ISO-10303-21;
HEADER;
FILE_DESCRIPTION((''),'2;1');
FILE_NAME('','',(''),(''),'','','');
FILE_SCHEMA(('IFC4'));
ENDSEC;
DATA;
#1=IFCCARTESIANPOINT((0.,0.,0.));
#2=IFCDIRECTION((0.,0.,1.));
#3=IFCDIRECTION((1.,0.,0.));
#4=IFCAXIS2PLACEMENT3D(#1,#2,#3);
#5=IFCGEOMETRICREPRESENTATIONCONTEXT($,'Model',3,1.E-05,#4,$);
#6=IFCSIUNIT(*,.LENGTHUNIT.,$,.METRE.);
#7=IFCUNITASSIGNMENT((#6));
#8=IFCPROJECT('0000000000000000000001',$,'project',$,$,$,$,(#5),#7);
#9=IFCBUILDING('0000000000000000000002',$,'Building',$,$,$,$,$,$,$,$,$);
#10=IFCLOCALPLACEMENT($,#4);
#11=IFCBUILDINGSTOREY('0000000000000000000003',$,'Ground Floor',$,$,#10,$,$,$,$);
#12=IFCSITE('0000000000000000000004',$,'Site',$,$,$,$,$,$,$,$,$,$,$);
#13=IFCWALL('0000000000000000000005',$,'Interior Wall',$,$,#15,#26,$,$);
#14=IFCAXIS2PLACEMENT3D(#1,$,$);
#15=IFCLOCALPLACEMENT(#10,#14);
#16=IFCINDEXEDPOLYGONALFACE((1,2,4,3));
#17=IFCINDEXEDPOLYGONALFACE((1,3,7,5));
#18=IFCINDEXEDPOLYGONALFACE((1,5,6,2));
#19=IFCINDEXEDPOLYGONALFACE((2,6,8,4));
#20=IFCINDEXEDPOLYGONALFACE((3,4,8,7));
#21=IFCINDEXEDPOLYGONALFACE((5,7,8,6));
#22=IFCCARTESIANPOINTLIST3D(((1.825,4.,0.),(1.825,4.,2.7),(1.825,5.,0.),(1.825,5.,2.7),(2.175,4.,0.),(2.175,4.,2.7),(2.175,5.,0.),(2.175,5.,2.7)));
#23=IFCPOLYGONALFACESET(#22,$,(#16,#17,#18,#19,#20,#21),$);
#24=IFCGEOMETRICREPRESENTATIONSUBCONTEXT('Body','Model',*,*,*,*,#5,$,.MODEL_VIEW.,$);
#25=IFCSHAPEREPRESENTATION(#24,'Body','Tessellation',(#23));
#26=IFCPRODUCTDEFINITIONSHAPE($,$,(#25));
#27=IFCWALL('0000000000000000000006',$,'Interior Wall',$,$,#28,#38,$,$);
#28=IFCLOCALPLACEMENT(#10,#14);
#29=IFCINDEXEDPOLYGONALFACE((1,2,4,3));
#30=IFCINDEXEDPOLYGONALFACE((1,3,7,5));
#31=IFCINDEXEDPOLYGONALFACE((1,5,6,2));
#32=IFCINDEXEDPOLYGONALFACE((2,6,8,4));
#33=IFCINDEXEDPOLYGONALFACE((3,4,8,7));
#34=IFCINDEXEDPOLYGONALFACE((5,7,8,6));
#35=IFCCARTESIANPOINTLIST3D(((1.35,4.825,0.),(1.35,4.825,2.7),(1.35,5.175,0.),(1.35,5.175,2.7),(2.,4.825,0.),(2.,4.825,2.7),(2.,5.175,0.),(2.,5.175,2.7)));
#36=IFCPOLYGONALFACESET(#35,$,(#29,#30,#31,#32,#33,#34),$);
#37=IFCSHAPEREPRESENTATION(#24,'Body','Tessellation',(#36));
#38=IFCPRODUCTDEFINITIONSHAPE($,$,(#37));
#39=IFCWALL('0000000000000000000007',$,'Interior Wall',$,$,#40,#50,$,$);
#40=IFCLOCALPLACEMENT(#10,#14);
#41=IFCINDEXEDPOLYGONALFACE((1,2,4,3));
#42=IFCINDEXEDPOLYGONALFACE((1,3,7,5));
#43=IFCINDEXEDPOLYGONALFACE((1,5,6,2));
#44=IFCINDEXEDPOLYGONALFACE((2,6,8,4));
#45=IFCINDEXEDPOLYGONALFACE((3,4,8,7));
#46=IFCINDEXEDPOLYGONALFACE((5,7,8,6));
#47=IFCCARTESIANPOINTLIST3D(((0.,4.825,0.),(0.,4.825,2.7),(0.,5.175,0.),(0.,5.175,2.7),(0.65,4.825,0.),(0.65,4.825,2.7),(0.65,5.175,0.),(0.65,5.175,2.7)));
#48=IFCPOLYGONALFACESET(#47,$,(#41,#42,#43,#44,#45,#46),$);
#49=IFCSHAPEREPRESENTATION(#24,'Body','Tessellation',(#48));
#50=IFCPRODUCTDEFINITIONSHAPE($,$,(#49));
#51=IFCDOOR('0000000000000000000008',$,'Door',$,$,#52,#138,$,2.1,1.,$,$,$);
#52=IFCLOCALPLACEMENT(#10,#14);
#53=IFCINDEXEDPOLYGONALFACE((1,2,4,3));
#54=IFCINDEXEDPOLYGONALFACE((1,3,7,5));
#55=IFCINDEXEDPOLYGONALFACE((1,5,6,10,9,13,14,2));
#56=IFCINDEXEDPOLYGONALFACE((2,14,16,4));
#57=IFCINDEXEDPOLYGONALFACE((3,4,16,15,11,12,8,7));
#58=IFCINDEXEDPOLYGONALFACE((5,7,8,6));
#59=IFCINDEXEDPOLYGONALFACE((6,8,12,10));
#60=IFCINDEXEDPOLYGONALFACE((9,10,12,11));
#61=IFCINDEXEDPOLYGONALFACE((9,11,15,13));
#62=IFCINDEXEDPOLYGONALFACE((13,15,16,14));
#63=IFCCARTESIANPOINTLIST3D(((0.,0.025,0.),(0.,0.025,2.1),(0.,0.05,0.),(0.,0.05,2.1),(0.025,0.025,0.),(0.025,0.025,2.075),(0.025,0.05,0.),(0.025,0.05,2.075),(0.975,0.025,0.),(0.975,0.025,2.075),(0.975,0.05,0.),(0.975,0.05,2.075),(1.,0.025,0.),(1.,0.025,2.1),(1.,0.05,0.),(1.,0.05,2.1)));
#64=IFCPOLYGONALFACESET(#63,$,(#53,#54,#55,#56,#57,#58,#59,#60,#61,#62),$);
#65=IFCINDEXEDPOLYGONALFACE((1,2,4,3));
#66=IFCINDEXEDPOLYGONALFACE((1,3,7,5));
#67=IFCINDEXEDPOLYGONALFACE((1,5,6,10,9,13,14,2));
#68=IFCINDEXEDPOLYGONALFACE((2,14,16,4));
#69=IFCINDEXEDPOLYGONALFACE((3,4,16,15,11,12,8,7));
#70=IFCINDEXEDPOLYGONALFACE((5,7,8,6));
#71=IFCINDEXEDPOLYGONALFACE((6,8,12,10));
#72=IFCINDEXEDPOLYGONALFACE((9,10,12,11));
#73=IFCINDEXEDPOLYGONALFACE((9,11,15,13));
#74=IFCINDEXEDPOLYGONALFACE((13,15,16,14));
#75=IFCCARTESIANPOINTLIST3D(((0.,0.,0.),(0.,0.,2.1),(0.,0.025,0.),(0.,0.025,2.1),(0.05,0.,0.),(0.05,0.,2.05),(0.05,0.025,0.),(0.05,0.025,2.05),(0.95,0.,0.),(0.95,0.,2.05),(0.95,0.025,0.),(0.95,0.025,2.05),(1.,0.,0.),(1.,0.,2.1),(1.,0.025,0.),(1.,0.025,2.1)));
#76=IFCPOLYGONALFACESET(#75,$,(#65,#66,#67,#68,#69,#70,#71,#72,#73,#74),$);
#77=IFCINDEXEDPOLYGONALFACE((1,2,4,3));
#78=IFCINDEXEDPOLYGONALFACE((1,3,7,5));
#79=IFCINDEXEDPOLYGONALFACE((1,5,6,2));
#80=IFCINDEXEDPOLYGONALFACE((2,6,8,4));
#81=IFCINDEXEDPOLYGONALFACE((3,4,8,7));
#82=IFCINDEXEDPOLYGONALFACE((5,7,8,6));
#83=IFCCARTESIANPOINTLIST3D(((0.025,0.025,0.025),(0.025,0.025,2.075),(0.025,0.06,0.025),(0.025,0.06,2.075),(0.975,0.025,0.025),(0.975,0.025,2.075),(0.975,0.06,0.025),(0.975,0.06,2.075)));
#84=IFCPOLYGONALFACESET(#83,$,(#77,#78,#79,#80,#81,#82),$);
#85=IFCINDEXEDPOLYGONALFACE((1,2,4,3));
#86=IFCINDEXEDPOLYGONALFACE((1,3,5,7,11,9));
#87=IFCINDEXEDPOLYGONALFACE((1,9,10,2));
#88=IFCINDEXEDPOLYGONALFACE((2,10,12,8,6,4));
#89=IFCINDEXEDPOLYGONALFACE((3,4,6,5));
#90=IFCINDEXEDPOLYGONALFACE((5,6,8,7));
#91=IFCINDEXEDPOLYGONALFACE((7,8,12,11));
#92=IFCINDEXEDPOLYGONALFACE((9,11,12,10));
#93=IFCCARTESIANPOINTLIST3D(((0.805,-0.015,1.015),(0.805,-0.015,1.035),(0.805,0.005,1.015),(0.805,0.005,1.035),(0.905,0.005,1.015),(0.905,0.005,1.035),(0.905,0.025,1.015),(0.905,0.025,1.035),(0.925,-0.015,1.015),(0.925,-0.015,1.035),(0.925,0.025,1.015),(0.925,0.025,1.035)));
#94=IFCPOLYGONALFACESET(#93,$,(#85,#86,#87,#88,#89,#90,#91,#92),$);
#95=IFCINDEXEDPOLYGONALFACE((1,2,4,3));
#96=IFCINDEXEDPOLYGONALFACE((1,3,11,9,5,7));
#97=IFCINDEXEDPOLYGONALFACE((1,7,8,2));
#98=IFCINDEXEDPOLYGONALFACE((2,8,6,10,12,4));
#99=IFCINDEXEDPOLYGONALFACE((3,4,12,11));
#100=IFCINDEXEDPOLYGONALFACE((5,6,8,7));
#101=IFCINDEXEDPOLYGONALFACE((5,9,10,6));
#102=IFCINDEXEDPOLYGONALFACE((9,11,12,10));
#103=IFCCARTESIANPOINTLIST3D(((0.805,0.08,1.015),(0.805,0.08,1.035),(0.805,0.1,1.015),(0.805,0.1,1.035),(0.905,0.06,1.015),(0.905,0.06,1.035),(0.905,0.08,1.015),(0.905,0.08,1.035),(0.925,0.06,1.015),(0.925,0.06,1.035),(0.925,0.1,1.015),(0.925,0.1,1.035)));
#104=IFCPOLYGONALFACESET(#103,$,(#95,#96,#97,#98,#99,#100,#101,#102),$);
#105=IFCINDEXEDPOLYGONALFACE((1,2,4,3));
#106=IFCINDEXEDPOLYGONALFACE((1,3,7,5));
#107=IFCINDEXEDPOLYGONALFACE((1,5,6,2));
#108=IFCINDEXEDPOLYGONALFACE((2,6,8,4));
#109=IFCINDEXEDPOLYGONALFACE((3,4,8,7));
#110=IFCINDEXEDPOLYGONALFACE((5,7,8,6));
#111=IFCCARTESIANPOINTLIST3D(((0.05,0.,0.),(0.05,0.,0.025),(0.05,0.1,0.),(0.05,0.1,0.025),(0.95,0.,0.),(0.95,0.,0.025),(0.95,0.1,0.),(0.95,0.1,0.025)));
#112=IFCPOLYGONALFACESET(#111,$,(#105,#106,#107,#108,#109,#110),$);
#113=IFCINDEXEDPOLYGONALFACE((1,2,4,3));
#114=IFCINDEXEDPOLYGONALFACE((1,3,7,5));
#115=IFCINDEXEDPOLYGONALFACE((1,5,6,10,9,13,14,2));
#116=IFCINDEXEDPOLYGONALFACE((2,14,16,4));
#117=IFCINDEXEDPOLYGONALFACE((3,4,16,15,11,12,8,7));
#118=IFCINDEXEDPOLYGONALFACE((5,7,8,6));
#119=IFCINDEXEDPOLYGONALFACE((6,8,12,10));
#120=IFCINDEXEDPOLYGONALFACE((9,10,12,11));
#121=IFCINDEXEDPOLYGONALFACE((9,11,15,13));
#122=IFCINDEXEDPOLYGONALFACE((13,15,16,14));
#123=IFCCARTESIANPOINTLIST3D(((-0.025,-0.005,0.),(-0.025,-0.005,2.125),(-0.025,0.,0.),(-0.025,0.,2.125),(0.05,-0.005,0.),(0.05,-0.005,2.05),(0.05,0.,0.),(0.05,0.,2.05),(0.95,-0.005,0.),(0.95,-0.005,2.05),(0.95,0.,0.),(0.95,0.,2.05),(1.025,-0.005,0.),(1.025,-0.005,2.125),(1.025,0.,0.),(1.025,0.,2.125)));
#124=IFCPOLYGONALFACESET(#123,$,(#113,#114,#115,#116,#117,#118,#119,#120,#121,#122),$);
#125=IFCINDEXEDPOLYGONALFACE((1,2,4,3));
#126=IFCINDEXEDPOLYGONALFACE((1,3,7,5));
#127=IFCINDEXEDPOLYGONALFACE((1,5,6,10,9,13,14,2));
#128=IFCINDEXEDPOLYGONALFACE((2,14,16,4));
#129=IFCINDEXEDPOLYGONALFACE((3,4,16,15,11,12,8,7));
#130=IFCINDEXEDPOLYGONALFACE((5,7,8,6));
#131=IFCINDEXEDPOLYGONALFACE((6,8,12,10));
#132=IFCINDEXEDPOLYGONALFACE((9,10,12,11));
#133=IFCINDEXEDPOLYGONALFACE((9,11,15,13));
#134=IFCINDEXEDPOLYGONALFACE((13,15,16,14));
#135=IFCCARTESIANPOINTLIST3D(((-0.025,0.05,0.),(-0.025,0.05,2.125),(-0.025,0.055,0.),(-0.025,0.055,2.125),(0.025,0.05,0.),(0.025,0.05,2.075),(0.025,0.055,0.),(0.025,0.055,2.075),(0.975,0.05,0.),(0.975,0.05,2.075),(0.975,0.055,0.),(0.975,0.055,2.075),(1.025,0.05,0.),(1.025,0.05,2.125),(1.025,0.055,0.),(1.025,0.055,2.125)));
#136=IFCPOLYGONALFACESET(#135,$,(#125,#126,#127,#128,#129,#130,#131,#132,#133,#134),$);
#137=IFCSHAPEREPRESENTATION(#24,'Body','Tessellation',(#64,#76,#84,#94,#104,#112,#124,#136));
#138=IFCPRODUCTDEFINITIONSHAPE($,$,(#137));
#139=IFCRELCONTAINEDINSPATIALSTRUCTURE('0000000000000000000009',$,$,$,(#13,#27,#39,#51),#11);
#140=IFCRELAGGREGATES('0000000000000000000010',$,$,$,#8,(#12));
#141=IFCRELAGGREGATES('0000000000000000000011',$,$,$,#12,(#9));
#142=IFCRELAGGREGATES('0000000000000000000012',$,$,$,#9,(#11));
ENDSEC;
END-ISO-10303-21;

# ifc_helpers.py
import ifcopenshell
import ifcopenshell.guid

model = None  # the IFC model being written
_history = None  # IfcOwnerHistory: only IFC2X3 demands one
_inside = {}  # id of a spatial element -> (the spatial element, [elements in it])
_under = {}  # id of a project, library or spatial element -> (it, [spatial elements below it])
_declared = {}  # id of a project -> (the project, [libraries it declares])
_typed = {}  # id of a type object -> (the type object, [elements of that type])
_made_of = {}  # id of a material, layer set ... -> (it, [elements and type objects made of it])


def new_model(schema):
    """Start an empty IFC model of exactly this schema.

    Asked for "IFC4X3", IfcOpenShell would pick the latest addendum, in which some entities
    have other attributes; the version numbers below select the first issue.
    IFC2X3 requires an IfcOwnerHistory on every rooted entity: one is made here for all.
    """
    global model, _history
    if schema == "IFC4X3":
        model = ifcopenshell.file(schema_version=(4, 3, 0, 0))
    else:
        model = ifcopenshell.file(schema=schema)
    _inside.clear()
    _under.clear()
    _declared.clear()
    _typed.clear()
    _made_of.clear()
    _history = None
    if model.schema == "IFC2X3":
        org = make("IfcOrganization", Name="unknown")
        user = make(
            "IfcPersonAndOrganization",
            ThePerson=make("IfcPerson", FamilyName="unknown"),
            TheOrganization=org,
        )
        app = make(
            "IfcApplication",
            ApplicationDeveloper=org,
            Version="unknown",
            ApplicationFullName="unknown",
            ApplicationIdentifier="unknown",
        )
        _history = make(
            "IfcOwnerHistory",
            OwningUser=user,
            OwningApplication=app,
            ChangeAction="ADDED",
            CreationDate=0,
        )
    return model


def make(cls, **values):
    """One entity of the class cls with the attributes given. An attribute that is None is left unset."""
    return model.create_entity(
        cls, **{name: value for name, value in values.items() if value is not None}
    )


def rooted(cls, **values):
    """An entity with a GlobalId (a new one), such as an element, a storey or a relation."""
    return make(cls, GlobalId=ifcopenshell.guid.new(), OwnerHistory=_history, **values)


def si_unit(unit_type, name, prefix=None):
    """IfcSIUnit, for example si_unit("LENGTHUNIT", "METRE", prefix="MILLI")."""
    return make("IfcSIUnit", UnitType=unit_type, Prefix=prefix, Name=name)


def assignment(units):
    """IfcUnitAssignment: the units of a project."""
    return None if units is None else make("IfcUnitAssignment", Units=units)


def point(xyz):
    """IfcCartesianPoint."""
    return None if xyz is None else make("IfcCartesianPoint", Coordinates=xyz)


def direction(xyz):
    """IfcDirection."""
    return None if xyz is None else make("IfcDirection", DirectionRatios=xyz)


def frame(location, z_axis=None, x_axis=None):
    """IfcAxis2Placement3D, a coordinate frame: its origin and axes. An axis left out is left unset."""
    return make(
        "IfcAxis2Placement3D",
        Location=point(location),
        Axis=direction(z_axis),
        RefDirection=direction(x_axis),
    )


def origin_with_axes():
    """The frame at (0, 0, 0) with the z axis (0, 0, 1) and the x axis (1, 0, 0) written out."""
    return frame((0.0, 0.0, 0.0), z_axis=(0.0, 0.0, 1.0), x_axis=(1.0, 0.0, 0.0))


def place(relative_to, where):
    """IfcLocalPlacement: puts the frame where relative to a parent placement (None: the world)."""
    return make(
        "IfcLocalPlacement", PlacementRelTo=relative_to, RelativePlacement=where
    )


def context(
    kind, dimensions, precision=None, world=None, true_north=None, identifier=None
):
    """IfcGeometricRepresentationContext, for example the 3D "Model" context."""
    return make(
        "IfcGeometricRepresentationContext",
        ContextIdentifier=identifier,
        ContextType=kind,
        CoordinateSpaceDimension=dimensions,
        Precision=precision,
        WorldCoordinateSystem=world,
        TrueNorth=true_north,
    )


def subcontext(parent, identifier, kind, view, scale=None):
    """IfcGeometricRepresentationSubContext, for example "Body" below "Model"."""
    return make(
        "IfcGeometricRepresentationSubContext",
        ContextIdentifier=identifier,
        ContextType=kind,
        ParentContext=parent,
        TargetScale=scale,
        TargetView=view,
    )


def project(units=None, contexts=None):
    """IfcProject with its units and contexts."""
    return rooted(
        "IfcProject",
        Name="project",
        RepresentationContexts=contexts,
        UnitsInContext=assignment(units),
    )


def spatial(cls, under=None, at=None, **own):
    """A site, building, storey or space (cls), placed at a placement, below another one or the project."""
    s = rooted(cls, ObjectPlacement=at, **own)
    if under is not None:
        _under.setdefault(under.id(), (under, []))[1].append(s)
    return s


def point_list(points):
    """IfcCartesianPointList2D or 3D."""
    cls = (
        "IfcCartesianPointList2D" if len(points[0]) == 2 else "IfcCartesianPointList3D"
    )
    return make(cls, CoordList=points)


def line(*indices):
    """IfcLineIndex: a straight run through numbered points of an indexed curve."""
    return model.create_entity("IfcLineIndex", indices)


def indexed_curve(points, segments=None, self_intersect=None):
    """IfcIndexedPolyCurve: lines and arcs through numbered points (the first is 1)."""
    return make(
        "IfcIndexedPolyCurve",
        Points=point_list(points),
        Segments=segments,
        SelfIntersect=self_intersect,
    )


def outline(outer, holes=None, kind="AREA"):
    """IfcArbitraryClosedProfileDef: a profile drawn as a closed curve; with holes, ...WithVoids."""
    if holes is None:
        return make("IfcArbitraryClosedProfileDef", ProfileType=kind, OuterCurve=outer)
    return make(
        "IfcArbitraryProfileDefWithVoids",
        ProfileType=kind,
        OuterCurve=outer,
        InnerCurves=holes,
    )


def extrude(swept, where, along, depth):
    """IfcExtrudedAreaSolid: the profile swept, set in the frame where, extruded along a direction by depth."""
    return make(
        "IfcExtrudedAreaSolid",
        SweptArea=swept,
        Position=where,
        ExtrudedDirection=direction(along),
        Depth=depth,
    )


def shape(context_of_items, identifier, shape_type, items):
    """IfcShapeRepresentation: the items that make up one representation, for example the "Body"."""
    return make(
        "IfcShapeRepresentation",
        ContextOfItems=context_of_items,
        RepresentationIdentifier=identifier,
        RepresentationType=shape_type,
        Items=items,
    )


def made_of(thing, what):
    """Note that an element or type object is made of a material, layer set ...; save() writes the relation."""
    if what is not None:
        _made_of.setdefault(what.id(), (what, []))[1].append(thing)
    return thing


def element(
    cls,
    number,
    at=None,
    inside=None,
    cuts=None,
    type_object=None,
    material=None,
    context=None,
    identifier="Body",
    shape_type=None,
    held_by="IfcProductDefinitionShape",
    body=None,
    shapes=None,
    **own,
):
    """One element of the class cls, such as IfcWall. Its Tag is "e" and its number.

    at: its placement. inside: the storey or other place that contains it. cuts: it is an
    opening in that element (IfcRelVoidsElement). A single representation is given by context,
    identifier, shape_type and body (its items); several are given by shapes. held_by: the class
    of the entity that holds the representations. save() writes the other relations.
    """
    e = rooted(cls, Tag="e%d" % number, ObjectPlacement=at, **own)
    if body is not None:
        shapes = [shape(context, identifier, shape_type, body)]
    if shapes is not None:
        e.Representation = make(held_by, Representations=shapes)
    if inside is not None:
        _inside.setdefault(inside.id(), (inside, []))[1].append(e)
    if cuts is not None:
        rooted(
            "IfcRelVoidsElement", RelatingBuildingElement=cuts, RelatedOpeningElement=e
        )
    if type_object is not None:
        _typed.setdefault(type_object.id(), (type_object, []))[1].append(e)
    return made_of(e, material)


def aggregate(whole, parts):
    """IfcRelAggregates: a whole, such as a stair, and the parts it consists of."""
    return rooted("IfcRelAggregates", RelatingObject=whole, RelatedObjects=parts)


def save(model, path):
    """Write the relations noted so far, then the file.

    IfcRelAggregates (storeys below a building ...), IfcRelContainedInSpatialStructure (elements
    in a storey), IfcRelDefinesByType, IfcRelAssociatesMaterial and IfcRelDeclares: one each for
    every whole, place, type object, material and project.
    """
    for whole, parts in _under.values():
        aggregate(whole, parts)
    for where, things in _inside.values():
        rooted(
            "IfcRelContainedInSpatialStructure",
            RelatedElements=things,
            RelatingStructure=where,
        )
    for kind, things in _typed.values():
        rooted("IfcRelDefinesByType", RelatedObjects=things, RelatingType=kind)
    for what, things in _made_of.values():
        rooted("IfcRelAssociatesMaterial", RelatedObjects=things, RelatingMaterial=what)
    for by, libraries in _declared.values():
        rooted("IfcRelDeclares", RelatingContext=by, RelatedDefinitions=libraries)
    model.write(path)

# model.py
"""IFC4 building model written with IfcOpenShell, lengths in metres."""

from ifc_helpers import new_model, si_unit, frame, origin_with_axes, place, context, subcontext, project, spatial, line, indexed_curve, outline, extrude, element, save


model = new_model("IFC4")

# Units and contexts
model_context = context("Model", 3, precision=1e-05, world=origin_with_axes())
body_context = subcontext(model_context, "Body", "Model", "MODEL_VIEW")
ifc_project = project(units=[si_unit("LENGTHUNIT", "METRE")], contexts=[model_context])

# Site, building, storey
site = spatial("IfcSite", under=ifc_project, Name="Site")
building = spatial("IfcBuilding", under=site, Name="Building")
storey_placement = place(None, origin_with_axes())
storey = spatial("IfcBuildingStorey", under=building, at=storey_placement, Name="Ground Floor")

# Walls
wall_1_placement = place(storey_placement, frame((2.0, 5.0, 0.0), z_axis=(0.0, 0.0, 1.0), x_axis=(0.0, -1.0, 0.0)))
element("IfcWall", 1, at=wall_1_placement, inside=storey, Name="Interior Wall", context=body_context, shape_type="SweptSolid", body=[
    extrude(outline(indexed_curve([(0.0, 0.0), (0.0, 0.35), (1.0, 0.35), (1.0, 0.0), (0.0, 0.0)], self_intersect=False)), frame((0.0, -0.175, 0.0), z_axis=(0.0, 0.0, 1.0), x_axis=(1.0, 0.0, 0.0)), (0.0, 0.0, 1.0), 2.7),
])
for number, where, z_axis, x_axis, name in (
    (2, (2.0, 5.0, 0.0), (0.0, 0.0, 1.0), (-1.0, 0.0, 0.0), "Interior Wall"),
    (3, (0.65, 5.0, 0.0), (0.0, 0.0, 1.0), (-1.0, 0.0, 0.0), "Interior Wall"),
):
    element("IfcWall", number, at=place(storey_placement, frame(where, z_axis=z_axis, x_axis=x_axis)), inside=storey, Name=name, context=body_context, shape_type="SweptSolid", body=[
        extrude(outline(indexed_curve([(0.0, 0.0), (0.0, 0.35), (0.65, 0.35), (0.65, 0.0), (0.0, 0.0)], self_intersect=False)), frame((0.0, -0.175, 0.0), z_axis=(0.0, 0.0, 1.0), x_axis=(1.0, 0.0, 0.0)), (0.0, 0.0, 1.0), 2.7),
    ])

# Door
door_1_placement = place(storey_placement, origin_with_axes())
element("IfcDoor", 4, at=door_1_placement, inside=storey, Name="Door", OverallHeight=2.1, OverallWidth=1.0, context=body_context, shape_type="SweptSolid", body=[
    extrude(outline(indexed_curve([(0.0, 0.0), (0.0, 2.1), (1.0, 2.1), (1.0, 0.0), (0.975, 0.0), (0.975, 2.075), (0.025, 2.075), (0.025, 0.0)], segments=[line(1, 2, 3, 4, 5, 6, 7, 8, 1)])), frame((0.0, 0.025, 0.0), z_axis=(0.0, -1.0, 0.0), x_axis=(1.0, 0.0, 0.0)), (0.0, 0.0, -1.0), 0.025),
    extrude(outline(indexed_curve([(0.0, 0.0), (0.0, 2.1), (1.0, 2.1), (1.0, 0.0), (0.95, 0.0), (0.95, 2.05), (0.05, 2.05), (0.05, 0.0)], segments=[line(1, 2, 3, 4, 5, 6, 7, 8, 1)])), frame((0.0, 0.0, 0.0), z_axis=(0.0, -1.0, 0.0), x_axis=(1.0, 0.0, 0.0)), (0.0, 0.0, -1.0), 0.025),
    extrude(outline(indexed_curve([(0.0, 0.0), (0.95, 0.0), (0.95, 0.035), (0.0, 0.035)], segments=[line(1, 2, 3, 4, 1)])), frame((0.025, 0.025, 0.025), z_axis=(0.0, 0.0, 1.0), x_axis=(1.0, 0.0, 0.0)), (0.0, 0.0, 1.0), 2.05),
    extrude(outline(indexed_curve([(0.0, 0.0), (0.0, -0.04), (-0.12, -0.04), (-0.12, -0.02), (-0.02, -0.02), (-0.02, 0.0)], segments=[line(1, 2, 3, 4, 5, 6, 1)])), frame((0.925, 0.025, 1.015), z_axis=(0.0, 0.0, 1.0), x_axis=(1.0, 0.0, 0.0)), (0.0, 0.0, 1.0), 0.02),
    extrude(outline(indexed_curve([(0.0, 0.0), (0.0, 0.04), (-0.12, 0.04), (-0.12, 0.02), (-0.02, 0.02), (-0.02, 0.0)], segments=[line(1, 2, 3, 4, 5, 6, 1)])), frame((0.925, 0.06, 1.015), z_axis=(0.0, 0.0, 1.0), x_axis=(1.0, 0.0, 0.0)), (0.0, 0.0, 1.0), 0.02),
    extrude(outline(indexed_curve([(0.0, 0.0), (0.9, 0.0), (0.9, 0.1), (0.0, 0.1)], segments=[line(1, 2, 3, 4, 1)])), frame((0.05, 0.0, 0.0), z_axis=(0.0, 0.0, 1.0), x_axis=(1.0, 0.0, 0.0)), (0.0, 0.0, 1.0), 0.025),
    extrude(outline(indexed_curve([(0.0, 0.0), (0.0, 2.125), (1.05, 2.125), (1.05, 0.0), (0.975, 0.0), (0.975, 2.05), (0.075, 2.05), (0.075, 0.0)], segments=[line(1, 2, 3, 4, 5, 6, 7, 8, 1)])), frame((-0.025, -0.005, 0.0), z_axis=(0.0, -1.0, 0.0), x_axis=(1.0, 0.0, 0.0)), (0.0, 0.0, -1.0), 0.005),
    extrude(outline(indexed_curve([(0.0, 0.0), (0.0, 2.125), (1.05, 2.125), (1.05, 0.0), (1.0, 0.0), (1.0, 2.075), (0.05, 2.075), (0.05, 0.0)], segments=[line(1, 2, 3, 4, 5, 6, 7, 8, 1)])), frame((-0.025, 0.05, 0.0), z_axis=(0.0, -1.0, 0.0), x_axis=(1.0, 0.0, 0.0)), (0.0, 0.0, -1.0), 0.005),
])

save(model, "model.ifc")
